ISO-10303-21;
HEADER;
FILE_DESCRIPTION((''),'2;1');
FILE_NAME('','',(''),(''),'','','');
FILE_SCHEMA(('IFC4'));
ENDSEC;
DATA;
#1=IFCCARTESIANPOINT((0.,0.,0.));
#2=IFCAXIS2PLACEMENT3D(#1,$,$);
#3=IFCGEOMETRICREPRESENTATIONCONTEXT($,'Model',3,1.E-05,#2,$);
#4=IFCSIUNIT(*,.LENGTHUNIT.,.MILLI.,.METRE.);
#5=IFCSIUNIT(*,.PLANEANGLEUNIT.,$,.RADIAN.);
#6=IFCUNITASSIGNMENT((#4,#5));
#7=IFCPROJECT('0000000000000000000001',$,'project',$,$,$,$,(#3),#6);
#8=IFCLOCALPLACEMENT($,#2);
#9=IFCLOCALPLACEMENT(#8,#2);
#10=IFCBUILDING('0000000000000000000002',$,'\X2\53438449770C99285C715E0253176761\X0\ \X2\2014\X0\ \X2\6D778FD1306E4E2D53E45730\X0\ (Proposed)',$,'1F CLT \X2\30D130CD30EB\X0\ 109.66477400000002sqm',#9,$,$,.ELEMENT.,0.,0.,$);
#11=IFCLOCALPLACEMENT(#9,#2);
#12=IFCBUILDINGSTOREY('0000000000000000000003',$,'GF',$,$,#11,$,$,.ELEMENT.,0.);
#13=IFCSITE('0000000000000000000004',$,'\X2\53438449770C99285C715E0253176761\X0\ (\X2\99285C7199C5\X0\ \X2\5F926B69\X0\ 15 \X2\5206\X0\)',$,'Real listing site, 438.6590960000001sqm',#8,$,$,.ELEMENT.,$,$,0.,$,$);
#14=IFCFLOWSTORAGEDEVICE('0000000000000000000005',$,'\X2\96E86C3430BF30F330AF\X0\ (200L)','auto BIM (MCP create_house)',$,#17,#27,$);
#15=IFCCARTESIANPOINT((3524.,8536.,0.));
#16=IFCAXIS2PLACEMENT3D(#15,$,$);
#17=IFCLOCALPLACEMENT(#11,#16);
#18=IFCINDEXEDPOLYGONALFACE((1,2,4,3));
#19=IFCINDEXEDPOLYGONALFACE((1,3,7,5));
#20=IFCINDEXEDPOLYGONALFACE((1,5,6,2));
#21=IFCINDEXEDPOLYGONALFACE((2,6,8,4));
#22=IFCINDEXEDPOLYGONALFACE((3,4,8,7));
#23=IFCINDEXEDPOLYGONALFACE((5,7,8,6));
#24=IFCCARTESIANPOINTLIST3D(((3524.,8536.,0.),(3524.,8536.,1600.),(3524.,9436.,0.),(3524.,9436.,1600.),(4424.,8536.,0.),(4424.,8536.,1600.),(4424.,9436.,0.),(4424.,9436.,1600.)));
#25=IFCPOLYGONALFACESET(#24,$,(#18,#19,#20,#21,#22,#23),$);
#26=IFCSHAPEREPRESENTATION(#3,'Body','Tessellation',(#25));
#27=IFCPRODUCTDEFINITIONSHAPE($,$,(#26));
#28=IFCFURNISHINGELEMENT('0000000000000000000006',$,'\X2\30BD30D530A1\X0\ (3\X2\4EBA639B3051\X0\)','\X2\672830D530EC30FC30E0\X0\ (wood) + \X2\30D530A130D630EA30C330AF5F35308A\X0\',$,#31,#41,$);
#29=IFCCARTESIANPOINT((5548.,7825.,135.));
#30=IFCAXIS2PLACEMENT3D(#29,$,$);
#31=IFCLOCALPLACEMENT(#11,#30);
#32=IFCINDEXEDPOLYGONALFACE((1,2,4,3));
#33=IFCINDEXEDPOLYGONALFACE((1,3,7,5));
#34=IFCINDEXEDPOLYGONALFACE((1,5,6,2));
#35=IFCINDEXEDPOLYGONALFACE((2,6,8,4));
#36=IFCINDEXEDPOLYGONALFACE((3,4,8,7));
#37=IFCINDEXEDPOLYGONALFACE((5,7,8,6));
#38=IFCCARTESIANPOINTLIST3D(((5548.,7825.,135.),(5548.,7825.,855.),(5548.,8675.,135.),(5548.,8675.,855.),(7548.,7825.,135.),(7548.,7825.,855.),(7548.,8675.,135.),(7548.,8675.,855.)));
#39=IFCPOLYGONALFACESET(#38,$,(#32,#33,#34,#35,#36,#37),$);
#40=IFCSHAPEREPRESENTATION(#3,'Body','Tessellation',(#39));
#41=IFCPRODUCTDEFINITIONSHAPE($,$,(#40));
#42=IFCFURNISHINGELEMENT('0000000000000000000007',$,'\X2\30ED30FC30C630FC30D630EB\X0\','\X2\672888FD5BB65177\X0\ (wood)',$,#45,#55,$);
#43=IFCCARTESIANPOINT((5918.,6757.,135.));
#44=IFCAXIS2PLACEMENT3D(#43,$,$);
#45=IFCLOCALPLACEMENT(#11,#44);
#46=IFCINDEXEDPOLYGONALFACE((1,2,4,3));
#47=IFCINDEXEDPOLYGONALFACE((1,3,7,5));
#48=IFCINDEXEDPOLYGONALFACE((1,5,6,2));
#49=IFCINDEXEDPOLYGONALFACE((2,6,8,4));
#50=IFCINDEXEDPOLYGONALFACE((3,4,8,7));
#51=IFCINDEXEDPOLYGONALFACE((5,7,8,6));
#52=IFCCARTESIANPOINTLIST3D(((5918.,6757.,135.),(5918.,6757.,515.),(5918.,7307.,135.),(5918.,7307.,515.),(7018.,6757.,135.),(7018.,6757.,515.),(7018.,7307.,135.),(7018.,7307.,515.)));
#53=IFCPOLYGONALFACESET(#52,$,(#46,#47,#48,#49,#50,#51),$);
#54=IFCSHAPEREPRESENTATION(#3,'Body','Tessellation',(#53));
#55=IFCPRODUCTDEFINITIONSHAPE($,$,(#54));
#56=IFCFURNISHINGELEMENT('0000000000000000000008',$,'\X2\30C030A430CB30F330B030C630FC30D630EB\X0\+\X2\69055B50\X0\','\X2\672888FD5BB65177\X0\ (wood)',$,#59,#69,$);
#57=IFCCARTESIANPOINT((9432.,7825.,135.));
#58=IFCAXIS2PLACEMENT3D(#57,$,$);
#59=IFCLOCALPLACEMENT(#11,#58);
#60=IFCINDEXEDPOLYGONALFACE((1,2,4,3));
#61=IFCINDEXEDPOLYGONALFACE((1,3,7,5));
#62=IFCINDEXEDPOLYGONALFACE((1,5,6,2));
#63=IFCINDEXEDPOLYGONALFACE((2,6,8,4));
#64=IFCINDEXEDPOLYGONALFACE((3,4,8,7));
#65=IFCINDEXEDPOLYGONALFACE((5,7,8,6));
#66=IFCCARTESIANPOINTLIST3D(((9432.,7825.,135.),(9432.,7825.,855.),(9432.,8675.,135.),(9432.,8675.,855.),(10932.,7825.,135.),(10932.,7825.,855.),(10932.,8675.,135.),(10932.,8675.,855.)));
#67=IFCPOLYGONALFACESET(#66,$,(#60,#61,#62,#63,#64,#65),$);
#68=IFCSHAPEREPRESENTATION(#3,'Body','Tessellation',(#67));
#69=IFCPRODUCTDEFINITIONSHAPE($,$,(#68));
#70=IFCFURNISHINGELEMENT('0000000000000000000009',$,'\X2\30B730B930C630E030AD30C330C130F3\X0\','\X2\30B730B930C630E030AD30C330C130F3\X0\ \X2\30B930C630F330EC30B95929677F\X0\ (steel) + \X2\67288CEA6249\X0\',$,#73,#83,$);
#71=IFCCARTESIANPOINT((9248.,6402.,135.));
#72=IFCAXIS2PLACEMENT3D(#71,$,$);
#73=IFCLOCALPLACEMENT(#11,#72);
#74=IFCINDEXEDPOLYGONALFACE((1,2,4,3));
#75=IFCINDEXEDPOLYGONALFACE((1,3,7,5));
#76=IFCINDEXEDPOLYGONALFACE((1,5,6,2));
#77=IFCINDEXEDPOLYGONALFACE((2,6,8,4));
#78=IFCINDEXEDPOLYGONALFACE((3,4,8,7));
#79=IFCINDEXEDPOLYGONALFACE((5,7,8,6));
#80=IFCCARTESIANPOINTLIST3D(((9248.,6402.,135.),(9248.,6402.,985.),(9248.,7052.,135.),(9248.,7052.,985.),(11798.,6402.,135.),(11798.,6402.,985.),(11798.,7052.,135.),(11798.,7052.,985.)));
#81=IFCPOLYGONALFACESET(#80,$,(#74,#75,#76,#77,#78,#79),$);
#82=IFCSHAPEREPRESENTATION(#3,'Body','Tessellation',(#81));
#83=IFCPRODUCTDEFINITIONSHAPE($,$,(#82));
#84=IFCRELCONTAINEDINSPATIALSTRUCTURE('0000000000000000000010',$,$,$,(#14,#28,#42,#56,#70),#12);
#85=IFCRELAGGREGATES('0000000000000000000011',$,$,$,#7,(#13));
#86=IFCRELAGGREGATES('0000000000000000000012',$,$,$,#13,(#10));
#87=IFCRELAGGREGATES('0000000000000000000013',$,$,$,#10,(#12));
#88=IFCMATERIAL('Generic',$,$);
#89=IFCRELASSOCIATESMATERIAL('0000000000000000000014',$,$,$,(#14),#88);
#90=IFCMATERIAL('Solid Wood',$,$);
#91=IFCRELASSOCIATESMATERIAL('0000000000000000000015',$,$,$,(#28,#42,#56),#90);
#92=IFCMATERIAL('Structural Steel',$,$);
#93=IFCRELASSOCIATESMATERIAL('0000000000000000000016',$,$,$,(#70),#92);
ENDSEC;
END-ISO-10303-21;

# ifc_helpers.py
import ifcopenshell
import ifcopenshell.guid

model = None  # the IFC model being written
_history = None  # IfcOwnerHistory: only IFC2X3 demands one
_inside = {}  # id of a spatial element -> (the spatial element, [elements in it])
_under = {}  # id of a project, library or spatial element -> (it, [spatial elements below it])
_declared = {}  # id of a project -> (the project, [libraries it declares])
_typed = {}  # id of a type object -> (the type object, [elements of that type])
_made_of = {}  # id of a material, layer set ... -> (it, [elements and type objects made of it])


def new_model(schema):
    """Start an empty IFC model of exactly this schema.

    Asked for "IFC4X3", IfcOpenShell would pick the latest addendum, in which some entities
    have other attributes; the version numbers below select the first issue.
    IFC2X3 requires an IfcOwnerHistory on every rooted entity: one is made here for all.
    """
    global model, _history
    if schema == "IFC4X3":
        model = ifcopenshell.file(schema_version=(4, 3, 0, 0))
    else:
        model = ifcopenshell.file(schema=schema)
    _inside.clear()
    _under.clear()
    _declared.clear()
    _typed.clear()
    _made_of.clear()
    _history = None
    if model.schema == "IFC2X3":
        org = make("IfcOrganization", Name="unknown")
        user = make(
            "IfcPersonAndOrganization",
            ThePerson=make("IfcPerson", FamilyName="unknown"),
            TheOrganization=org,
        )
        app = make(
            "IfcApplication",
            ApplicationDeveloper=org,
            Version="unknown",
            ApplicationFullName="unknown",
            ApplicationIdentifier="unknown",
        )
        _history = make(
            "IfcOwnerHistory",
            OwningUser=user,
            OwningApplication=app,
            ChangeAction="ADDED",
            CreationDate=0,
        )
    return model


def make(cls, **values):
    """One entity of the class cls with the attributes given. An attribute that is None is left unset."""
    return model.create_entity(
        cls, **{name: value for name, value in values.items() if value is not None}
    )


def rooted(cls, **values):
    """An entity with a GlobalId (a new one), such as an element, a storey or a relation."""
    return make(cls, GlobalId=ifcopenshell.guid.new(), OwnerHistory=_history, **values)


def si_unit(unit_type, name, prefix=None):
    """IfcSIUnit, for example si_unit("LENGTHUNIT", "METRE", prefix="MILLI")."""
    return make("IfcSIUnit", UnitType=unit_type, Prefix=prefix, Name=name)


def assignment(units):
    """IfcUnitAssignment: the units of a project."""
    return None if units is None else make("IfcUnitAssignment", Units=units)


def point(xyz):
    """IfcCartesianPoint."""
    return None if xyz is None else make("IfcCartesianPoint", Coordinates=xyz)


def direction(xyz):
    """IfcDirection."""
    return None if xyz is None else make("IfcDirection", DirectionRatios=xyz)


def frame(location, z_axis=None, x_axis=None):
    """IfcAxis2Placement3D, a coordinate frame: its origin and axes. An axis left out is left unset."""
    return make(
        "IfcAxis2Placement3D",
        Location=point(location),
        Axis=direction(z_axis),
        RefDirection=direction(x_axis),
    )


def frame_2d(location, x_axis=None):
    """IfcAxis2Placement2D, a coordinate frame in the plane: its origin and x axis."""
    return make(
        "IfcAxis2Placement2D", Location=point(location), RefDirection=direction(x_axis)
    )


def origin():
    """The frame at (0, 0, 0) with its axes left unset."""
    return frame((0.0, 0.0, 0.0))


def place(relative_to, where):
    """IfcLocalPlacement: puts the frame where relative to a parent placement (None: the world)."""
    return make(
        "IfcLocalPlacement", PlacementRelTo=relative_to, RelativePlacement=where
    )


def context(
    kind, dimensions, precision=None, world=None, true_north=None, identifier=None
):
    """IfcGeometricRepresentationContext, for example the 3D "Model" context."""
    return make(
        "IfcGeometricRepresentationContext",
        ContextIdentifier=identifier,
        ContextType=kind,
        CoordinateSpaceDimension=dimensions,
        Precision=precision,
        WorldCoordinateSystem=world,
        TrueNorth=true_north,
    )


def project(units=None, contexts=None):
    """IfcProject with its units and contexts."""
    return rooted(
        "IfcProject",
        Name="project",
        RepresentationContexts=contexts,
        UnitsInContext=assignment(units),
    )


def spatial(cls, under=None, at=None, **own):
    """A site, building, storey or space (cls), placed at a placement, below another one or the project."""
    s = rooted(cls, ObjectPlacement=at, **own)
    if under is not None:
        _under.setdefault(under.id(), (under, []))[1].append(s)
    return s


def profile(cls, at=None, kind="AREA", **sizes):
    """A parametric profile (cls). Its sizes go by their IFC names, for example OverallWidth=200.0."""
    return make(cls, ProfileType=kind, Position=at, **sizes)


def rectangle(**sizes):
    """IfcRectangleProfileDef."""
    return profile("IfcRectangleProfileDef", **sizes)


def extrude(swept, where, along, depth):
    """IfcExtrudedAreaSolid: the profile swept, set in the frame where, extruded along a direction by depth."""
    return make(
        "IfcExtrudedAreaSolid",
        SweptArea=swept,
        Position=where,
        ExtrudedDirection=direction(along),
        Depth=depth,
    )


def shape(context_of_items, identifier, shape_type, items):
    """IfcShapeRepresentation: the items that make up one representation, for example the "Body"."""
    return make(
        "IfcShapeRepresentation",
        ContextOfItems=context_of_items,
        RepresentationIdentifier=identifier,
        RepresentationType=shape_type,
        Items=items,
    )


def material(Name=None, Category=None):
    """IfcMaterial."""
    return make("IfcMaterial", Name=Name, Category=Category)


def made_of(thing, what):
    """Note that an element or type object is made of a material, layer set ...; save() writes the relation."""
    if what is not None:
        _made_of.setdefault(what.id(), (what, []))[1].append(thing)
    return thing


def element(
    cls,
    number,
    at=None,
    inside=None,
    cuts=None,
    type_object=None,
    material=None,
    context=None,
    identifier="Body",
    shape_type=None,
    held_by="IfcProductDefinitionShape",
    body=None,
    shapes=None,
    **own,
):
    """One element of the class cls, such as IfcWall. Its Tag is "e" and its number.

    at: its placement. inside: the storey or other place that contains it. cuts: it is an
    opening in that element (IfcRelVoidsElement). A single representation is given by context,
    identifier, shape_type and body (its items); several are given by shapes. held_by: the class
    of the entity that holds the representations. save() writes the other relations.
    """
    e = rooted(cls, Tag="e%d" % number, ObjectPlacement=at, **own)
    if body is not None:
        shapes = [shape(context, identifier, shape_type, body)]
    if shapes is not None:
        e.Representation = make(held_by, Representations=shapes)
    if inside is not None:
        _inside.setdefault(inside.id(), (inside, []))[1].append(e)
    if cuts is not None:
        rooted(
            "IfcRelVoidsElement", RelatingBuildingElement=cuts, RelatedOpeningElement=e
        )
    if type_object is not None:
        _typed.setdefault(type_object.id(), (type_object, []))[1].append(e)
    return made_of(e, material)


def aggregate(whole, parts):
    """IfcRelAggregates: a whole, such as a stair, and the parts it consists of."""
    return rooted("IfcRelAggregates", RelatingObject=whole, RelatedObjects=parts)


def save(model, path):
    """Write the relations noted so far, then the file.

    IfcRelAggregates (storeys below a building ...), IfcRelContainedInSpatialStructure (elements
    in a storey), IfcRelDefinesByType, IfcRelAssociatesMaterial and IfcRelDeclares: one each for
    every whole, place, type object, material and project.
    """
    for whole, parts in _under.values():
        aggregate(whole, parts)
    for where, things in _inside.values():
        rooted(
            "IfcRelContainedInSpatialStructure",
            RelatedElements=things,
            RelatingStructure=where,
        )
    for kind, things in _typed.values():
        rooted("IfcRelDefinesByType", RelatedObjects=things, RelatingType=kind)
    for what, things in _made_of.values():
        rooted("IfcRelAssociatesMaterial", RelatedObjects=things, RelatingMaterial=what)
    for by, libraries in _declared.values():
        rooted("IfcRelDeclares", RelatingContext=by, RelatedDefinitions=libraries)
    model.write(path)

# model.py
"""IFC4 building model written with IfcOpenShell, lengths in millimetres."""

from ifc_helpers import new_model, si_unit, frame, frame_2d, origin, place, context, project, spatial, rectangle, extrude, material, element, save


model = new_model("IFC4")

# Units and contexts
model_context = context("Model", 3, precision=1e-05, world=origin())
ifc_project = project(units=[si_unit("LENGTHUNIT", "METRE", prefix="MILLI"), si_unit("PLANEANGLEUNIT", "RADIAN")], contexts=[model_context])

# Site, building, storey
site_placement = place(None, origin())
site = spatial("IfcSite", under=ifc_project, at=site_placement, Name="千葉県館山市北条 (館山駅 徒歩 15 分)", ObjectType="Real listing site, 438.6590960000001sqm", CompositionType="ELEMENT", RefElevation=0.0)
building_placement = place(site_placement, origin())
building = spatial("IfcBuilding", under=site, at=building_placement, Name="千葉県館山市北条 — 海近の中古地 (Proposed)", ObjectType="1F CLT パネル 109.66477400000002sqm", CompositionType="ELEMENT", ElevationOfRefHeight=0.0, ElevationOfTerrain=0.0)
storey_placement = place(building_placement, origin())
storey = spatial("IfcBuildingStorey", under=building, at=storey_placement, Name="GF", CompositionType="ELEMENT", Elevation=0.0)

# Shared definitions
ifc_material_1 = material(Name="Solid Wood")

# Shared definitions
ifc_material_2 = material(Name="Structural Steel")

# Shared definitions
ifc_material_3 = material(Name="Generic")

# Flow storage device
flow_storage_device_placement = place(storey_placement, frame((3524.0, 8536.0, 0.0)))
element("IfcFlowStorageDevice", 1, at=flow_storage_device_placement, inside=storey, material=ifc_material_3, Name="雨水タンク (200L)", Description="auto BIM (MCP create_house)", context=model_context, shape_type="SweptSolid", body=[
    extrude(rectangle(XDim=900.0, YDim=900.0, at=frame_2d((450.0, 450.0))), frame((3524.0, 8536.0, 0.0)), (0.0, 0.0, 1.0), 1600.0),
])

# Furnishing elements
furnishing_1_placement = place(storey_placement, frame((5548.0, 7825.0, 135.0)))
element("IfcFurnishingElement", 2, at=furnishing_1_placement, inside=storey, material=ifc_material_1, Name="ソファ (3人掛け)", Description="木フレーム (wood) + ファブリック張り", context=model_context, shape_type="SweptSolid", body=[
    extrude(rectangle(XDim=2000.0, YDim=850.0, at=frame_2d((1000.0, 425.0))), frame((5548.0, 7825.0, 135.0)), (0.0, 0.0, 1.0), 720.0),
])
furnishing_2_placement = place(storey_placement, frame((5918.0, 6757.0, 135.0)))
element("IfcFurnishingElement", 3, at=furnishing_2_placement, inside=storey, material=ifc_material_1, Name="ローテーブル", Description="木製家具 (wood)", context=model_context, shape_type="SweptSolid", body=[
    extrude(rectangle(XDim=1100.0, YDim=550.0, at=frame_2d((550.0, 275.0))), frame((5918.0, 6757.0, 135.0)), (0.0, 0.0, 1.0), 380.0),
])
furnishing_3_placement = place(storey_placement, frame((9432.0, 7825.0, 135.0)))
element("IfcFurnishingElement", 4, at=furnishing_3_placement, inside=storey, material=ifc_material_1, Name="ダイニングテーブル+椅子", Description="木製家具 (wood)", context=model_context, shape_type="SweptSolid", body=[
    extrude(rectangle(XDim=1500.0, YDim=850.0, at=frame_2d((750.0, 425.0))), frame((9432.0, 7825.0, 135.0)), (0.0, 0.0, 1.0), 720.0),
])
furnishing_4_placement = place(storey_placement, frame((9248.0, 6402.0, 135.0)))
element("IfcFurnishingElement", 5, at=furnishing_4_placement, inside=storey, material=ifc_material_2, Name="システムキッチン", Description="システムキッチン ステンレス天板 (steel) + 木質扉", context=model_context, shape_type="SweptSolid", body=[
    extrude(rectangle(XDim=2550.0, YDim=650.0, at=frame_2d((1275.0, 325.0))), frame((9248.0, 6402.0, 135.0)), (0.0, 0.0, 1.0), 850.0),
])

save(model, "model.ifc")
